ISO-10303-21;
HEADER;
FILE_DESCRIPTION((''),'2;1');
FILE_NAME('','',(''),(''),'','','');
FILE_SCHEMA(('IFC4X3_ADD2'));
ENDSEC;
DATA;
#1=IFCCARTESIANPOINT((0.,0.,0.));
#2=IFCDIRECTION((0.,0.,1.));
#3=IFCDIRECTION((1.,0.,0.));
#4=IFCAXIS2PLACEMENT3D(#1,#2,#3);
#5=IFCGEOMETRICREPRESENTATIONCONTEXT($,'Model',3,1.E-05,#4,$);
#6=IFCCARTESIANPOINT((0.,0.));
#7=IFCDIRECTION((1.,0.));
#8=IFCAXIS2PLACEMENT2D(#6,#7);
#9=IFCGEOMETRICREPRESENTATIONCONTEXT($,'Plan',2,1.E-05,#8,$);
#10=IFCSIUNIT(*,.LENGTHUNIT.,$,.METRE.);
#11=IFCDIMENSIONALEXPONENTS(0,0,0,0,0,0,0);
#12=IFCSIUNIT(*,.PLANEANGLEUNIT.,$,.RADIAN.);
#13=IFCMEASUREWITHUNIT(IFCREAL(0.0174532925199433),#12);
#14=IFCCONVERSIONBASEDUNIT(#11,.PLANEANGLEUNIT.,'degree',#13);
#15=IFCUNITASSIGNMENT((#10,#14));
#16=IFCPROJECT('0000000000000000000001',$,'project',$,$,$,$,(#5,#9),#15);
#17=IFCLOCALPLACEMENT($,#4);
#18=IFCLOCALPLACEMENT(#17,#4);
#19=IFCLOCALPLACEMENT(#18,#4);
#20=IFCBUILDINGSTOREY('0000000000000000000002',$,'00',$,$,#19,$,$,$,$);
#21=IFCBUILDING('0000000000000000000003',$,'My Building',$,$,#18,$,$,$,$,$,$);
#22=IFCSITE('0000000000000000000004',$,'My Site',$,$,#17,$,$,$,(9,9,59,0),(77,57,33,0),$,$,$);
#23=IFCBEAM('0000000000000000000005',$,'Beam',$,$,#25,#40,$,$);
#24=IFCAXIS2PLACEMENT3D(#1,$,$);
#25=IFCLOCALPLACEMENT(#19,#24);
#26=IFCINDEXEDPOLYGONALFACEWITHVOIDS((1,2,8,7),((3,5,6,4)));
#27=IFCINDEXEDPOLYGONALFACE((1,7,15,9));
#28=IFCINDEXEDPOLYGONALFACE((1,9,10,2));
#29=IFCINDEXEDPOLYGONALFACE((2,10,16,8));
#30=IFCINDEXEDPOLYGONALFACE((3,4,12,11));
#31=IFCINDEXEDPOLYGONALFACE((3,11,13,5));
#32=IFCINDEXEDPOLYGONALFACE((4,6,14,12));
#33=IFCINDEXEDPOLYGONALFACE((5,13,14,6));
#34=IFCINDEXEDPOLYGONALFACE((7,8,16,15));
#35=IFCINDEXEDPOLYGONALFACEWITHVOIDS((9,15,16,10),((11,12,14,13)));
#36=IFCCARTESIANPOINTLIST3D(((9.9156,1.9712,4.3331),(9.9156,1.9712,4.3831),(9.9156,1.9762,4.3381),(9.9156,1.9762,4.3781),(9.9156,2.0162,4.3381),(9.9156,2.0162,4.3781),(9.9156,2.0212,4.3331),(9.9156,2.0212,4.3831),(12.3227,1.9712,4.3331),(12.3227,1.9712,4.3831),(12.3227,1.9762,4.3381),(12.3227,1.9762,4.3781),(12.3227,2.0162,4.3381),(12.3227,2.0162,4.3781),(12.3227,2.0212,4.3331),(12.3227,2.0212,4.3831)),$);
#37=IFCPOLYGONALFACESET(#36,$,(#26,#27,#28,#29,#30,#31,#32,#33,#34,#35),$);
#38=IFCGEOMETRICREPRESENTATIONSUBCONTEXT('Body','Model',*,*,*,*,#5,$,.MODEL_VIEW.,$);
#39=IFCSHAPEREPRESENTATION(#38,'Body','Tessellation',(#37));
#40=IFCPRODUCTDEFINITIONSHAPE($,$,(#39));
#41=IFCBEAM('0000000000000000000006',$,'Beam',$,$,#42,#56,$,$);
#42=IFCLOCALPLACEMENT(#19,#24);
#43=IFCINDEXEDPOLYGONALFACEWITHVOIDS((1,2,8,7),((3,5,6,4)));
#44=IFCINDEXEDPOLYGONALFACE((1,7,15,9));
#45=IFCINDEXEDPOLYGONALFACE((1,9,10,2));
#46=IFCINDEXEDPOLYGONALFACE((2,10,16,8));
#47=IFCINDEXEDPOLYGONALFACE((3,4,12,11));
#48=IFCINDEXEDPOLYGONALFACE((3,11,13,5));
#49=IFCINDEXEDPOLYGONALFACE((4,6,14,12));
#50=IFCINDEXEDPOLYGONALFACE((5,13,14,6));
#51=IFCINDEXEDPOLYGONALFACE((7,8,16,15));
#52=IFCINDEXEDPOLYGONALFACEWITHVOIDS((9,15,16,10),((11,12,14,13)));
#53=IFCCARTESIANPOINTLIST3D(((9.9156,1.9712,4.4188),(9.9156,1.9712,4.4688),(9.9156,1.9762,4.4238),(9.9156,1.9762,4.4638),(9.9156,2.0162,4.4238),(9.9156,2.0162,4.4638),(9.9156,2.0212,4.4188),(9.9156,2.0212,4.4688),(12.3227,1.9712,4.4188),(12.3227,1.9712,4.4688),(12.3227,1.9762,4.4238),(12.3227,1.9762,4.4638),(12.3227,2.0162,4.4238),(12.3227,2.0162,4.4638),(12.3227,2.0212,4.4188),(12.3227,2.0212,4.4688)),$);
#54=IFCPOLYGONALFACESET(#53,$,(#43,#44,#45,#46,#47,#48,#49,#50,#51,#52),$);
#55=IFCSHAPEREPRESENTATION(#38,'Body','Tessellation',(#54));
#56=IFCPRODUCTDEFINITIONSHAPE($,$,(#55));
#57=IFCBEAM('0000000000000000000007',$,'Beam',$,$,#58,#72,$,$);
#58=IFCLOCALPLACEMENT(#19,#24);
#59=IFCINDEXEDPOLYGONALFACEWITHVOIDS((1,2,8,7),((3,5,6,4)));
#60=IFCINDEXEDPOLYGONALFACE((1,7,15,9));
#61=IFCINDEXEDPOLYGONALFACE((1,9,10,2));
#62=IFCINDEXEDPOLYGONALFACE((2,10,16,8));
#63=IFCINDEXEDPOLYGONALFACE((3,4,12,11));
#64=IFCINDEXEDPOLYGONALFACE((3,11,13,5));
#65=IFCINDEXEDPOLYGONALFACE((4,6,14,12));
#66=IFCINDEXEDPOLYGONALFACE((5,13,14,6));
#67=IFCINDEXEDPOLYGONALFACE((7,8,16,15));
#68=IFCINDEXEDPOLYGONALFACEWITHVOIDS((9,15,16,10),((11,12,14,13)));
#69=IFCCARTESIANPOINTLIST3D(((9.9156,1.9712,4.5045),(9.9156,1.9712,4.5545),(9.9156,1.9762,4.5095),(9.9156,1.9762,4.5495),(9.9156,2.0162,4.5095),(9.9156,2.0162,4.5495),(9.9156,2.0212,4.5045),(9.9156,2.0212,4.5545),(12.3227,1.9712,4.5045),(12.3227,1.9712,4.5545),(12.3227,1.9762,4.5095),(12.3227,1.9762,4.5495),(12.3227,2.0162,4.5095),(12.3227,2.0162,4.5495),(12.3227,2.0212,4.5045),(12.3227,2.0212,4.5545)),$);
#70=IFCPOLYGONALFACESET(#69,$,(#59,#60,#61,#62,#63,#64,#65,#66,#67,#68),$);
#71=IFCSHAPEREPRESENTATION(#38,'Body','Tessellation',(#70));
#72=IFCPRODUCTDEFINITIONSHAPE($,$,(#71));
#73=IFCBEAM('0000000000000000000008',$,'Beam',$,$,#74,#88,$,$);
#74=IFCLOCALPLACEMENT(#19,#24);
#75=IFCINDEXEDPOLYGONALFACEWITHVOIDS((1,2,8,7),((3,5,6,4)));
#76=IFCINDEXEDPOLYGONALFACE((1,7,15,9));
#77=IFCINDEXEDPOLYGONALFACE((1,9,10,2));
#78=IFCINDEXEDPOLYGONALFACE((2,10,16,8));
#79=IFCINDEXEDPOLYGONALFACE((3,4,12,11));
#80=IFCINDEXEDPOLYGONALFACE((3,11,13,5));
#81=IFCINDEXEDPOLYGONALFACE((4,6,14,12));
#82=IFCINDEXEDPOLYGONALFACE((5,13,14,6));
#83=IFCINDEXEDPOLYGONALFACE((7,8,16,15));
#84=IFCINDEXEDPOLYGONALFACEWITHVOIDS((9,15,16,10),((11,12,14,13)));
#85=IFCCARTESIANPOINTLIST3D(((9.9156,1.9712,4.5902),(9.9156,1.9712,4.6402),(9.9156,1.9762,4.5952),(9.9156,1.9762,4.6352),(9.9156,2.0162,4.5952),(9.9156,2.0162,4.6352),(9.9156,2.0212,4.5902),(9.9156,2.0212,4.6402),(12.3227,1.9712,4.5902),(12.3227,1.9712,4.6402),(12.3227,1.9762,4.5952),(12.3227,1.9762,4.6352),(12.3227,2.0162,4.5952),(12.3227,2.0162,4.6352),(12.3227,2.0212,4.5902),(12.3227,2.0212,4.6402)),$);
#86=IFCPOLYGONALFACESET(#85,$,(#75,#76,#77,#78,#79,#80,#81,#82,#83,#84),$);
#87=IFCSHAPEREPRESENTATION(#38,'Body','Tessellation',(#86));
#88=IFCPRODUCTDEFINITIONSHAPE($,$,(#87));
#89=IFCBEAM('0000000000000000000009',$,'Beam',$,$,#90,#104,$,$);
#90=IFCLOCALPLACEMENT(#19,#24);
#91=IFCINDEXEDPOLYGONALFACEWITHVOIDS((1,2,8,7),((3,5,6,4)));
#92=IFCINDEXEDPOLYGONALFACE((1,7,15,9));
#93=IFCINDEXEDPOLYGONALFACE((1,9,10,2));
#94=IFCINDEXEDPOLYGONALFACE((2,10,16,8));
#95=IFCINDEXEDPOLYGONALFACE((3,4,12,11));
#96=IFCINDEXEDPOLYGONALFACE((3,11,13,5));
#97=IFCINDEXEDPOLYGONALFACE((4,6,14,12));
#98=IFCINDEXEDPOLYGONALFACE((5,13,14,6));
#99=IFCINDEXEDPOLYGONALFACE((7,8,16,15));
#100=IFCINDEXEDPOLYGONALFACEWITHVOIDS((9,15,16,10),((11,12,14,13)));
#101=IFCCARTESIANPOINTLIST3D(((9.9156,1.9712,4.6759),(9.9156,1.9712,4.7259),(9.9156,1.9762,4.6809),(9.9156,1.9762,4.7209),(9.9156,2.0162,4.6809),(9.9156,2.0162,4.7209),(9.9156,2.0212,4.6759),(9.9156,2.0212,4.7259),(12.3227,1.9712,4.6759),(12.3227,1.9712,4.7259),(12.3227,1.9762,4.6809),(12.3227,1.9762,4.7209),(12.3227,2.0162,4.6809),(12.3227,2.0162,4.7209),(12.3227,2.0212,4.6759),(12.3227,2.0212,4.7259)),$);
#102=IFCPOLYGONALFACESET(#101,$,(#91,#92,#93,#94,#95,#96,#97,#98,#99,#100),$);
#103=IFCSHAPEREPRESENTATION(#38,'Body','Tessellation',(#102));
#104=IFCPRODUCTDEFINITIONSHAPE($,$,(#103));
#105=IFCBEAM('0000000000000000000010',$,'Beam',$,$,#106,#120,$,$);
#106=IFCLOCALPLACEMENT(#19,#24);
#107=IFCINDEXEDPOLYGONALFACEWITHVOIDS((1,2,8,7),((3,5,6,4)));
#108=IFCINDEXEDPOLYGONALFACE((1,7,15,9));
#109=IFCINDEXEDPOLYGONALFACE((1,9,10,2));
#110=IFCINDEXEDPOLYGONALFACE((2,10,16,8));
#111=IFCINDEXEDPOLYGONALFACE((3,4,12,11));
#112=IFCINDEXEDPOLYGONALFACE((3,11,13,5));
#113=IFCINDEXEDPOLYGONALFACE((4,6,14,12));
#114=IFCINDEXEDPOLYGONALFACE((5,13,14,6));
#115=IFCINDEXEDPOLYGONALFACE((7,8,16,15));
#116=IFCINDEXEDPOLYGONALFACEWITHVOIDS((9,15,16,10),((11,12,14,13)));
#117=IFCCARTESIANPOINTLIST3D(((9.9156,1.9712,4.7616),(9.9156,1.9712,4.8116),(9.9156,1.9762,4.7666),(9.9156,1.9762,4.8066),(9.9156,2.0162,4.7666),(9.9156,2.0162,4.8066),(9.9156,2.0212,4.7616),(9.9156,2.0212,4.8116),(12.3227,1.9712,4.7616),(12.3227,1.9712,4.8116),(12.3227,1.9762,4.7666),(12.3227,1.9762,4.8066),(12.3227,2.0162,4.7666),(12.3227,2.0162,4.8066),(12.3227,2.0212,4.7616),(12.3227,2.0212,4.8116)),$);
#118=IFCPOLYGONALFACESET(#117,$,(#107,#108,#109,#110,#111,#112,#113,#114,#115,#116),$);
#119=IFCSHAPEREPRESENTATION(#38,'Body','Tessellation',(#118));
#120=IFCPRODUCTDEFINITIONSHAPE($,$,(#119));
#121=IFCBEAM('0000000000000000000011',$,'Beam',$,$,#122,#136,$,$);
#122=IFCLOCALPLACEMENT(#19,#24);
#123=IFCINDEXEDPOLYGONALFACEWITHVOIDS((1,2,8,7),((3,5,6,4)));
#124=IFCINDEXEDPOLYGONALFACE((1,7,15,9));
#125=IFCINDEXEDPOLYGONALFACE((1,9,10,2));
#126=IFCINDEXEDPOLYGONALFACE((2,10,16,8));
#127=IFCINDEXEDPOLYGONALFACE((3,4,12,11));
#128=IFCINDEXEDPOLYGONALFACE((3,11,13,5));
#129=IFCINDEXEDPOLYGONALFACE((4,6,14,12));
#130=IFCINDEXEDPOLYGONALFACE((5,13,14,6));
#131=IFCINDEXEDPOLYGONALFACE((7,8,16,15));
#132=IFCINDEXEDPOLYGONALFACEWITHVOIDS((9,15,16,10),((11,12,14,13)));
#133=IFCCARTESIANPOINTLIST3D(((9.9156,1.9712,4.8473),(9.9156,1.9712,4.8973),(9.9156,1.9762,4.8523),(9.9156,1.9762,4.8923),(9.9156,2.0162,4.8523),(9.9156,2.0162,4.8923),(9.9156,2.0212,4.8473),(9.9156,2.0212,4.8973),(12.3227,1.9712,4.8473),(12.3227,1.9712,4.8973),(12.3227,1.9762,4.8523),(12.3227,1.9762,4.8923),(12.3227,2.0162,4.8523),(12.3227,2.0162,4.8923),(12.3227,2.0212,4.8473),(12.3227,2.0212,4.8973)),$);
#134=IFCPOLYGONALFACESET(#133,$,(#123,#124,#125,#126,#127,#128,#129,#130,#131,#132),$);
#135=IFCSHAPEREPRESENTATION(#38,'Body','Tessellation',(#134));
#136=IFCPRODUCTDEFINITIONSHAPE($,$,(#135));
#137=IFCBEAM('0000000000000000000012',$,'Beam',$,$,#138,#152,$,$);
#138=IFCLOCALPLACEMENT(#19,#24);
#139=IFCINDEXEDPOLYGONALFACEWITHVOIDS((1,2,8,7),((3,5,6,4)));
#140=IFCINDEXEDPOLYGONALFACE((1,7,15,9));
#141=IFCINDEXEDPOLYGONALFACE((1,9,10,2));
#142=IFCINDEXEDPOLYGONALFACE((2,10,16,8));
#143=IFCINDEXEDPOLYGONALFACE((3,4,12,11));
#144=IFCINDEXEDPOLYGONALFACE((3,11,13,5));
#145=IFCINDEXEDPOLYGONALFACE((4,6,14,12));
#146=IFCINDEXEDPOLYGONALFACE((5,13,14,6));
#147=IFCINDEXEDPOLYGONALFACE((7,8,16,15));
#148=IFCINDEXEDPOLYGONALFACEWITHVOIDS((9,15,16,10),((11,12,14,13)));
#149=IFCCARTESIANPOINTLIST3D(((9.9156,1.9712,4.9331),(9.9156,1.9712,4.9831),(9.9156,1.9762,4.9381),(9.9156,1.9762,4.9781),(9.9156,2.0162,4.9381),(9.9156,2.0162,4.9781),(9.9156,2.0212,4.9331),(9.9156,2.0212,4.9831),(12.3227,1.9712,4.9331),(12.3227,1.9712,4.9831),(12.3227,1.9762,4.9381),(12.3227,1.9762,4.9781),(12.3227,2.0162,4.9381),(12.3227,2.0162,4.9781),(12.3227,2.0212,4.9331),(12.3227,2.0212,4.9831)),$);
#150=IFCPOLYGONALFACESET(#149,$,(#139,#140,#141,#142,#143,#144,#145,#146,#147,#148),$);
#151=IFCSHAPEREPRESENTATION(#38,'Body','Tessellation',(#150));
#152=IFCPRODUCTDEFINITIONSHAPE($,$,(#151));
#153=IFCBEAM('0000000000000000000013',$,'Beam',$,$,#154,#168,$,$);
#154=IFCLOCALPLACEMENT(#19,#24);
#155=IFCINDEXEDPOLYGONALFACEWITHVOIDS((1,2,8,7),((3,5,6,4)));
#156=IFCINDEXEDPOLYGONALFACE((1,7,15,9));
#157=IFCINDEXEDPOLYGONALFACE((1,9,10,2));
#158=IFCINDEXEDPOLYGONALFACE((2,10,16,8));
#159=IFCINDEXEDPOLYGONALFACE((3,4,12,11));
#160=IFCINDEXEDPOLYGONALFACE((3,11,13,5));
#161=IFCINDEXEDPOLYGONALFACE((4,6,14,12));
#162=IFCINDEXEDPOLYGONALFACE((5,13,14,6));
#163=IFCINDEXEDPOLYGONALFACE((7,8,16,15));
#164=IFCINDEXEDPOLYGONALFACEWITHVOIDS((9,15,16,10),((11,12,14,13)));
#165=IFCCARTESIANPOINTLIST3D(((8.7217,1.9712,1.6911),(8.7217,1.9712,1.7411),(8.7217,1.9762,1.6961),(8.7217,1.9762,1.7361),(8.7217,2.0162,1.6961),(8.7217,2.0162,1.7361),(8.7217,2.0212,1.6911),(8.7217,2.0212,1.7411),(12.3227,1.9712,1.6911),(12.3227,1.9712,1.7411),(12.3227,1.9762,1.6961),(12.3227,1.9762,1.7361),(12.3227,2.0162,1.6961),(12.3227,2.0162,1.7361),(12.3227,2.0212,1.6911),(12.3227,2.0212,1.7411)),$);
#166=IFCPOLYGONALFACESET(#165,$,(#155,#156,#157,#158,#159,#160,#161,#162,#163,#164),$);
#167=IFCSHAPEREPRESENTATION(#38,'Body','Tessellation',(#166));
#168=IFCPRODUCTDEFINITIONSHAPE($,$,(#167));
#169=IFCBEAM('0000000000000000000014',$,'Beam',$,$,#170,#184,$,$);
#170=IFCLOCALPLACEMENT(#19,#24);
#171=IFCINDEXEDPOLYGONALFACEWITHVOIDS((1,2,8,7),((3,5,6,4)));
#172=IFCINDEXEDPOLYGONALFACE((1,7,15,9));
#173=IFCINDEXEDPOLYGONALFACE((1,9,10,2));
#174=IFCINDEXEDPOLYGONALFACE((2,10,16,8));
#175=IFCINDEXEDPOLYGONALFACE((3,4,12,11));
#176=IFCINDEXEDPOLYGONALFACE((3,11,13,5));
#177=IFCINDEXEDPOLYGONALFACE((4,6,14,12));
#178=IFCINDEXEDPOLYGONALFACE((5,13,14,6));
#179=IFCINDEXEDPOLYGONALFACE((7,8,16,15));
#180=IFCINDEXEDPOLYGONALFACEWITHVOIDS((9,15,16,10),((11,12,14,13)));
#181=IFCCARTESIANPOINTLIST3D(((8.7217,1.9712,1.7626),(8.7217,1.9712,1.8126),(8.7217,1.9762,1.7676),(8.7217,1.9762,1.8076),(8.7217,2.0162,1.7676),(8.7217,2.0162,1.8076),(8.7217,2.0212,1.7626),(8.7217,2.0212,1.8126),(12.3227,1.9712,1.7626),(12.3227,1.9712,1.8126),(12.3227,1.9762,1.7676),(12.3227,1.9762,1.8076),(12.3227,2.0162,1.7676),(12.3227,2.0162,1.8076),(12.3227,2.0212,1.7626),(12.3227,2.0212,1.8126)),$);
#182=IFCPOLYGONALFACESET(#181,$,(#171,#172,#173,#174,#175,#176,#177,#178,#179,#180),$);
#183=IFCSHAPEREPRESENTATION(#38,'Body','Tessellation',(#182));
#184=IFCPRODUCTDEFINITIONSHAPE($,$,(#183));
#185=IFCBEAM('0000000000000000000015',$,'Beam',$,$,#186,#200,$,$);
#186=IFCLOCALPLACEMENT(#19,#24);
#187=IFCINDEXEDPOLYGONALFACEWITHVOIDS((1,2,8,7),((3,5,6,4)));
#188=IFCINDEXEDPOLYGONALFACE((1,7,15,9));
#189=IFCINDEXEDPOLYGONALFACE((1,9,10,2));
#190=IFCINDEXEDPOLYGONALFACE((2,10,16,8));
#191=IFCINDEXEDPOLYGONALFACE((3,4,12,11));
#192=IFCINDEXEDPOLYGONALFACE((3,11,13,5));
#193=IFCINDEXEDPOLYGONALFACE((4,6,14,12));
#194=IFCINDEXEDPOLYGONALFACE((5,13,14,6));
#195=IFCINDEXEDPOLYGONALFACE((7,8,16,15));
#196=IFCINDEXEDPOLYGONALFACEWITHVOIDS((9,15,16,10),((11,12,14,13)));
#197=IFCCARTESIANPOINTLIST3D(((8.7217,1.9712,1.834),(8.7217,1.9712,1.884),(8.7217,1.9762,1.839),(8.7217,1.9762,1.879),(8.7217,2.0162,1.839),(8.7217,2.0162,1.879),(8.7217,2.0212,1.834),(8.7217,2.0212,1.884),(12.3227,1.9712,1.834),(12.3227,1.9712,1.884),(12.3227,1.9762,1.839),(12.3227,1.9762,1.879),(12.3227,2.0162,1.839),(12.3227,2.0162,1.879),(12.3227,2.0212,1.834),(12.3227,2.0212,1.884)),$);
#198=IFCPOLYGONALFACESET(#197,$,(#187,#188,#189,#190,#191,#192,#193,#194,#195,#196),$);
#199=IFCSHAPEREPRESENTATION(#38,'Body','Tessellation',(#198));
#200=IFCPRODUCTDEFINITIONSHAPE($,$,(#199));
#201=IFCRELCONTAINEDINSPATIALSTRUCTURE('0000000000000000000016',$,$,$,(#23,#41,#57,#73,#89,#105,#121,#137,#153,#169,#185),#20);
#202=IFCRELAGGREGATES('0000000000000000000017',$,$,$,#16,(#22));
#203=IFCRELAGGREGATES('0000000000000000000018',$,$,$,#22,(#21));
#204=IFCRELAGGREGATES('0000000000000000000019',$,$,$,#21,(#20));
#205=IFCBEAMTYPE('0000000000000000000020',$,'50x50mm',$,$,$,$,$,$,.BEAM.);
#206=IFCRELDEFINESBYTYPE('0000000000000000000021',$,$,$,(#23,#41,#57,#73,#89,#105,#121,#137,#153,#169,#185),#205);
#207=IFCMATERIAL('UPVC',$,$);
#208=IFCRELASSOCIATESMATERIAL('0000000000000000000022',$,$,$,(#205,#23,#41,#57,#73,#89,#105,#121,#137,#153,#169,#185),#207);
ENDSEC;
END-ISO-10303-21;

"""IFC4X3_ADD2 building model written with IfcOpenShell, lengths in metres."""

from ifc_helpers import new_model, entity, si_unit, converted_unit, frame, origin_with_axes, origin_2d_with_axis, place, context, subcontext, project, spatial, hollow_rectangle, extrude, material, material_profile, profile_set, profile_usage, type_object, element, save


model = new_model("IFC4X3_ADD2")

# Units and contexts
model_context = context("Model", 3, precision=1e-05, world=origin_with_axes())
plan_context = context("Plan", 2, precision=1e-05, world=origin_2d_with_axis())
body_context = subcontext(model_context, "Body", "Model", "MODEL_VIEW")
ifc_project = project(units=[si_unit("LENGTHUNIT", "METRE"), converted_unit("PLANEANGLEUNIT", "degree", entity("IfcReal", 0.0174532925199433), si_unit("PLANEANGLEUNIT", "RADIAN"), dimensions=[0, 0, 0, 0, 0, 0, 0])], contexts=[model_context, plan_context])

# Site, building, storey
site_placement = place(None, origin_with_axes())
site = spatial("IfcSite", under=ifc_project, at=site_placement, Name="My Site", RefLatitude=(9, 9, 59, 0), RefLongitude=(77, 57, 33, 0))
building_placement = place(site_placement, origin_with_axes())
building = spatial("IfcBuilding", under=site, at=building_placement, Name="My Building")
storey_placement = place(building_placement, origin_with_axes())
storey = spatial("IfcBuildingStorey", under=building, at=storey_placement, Name="00")

# Shared definitions
ifc_material_1 = material(Name="UPVC")

# Beams
ifc_material_profile_1 = material_profile(ifc_material_1, hollow_rectangle(XDim=0.05, YDim=0.05, WallThickness=0.005))
ifc_profile_set_1 = profile_set([ifc_material_profile_1])
beam_type = type_object("IfcBeamType", Name="50x50mm", PredefinedType="BEAM", material=ifc_profile_set_1)
ifc_profile_usage_1 = profile_usage(ifc_profile_set_1, cardinal=5)
beam_1_placement = place(storey_placement, frame((9.9156, 1.9962, 4.3581), z_axis=(1.0, 0.0, 0.000001), x_axis=(0.0, 1.0, 0.0)))
element("IfcBeam", 1, at=beam_1_placement, inside=storey, type_object=beam_type, material=ifc_profile_usage_1, Name="Beam", context=body_context, shape_type="SweptSolid", body=[
    extrude(hollow_rectangle(XDim=0.05, YDim=0.05, WallThickness=0.005), origin_with_axes(), (0.0, 0.0, 1.0), 2.4071),
])
ifc_profile_usage_2 = profile_usage(ifc_profile_set_1, cardinal=5)
beam_2_placement = place(storey_placement, frame((9.9156, 1.9962, 4.4438), z_axis=(1.0, 0.0, 0.000001), x_axis=(0.0, 1.0, 0.0)))
element("IfcBeam", 2, at=beam_2_placement, inside=storey, type_object=beam_type, material=ifc_profile_usage_2, Name="Beam", context=body_context, shape_type="SweptSolid", body=[
    extrude(hollow_rectangle(XDim=0.05, YDim=0.05, WallThickness=0.005), origin_with_axes(), (0.0, 0.0, 1.0), 2.4071),
])
ifc_profile_usage_3 = profile_usage(ifc_profile_set_1, cardinal=5)
beam_3_placement = place(storey_placement, frame((9.9156, 1.9962, 4.5295), z_axis=(1.0, 0.0, 0.000001), x_axis=(0.0, 1.0, 0.0)))
element("IfcBeam", 3, at=beam_3_placement, inside=storey, type_object=beam_type, material=ifc_profile_usage_3, Name="Beam", context=body_context, shape_type="SweptSolid", body=[
    extrude(hollow_rectangle(XDim=0.05, YDim=0.05, WallThickness=0.005), origin_with_axes(), (0.0, 0.0, 1.0), 2.4071),
])
ifc_profile_usage_4 = profile_usage(ifc_profile_set_1, cardinal=5)
beam_4_placement = place(storey_placement, frame((9.9156, 1.9962, 4.6152), z_axis=(1.0, 0.0, 0.000001), x_axis=(0.0, 1.0, 0.0)))
element("IfcBeam", 4, at=beam_4_placement, inside=storey, type_object=beam_type, material=ifc_profile_usage_4, Name="Beam", context=body_context, shape_type="SweptSolid", body=[
    extrude(hollow_rectangle(XDim=0.05, YDim=0.05, WallThickness=0.005), origin_with_axes(), (0.0, 0.0, 1.0), 2.4071),
])
ifc_profile_usage_5 = profile_usage(ifc_profile_set_1, cardinal=5)
beam_5_placement = place(storey_placement, frame((9.9156, 1.9962, 4.7009), z_axis=(1.0, 0.0, 0.000001), x_axis=(0.0, 1.0, 0.0)))
element("IfcBeam", 5, at=beam_5_placement, inside=storey, type_object=beam_type, material=ifc_profile_usage_5, Name="Beam", context=body_context, shape_type="SweptSolid", body=[
    extrude(hollow_rectangle(XDim=0.05, YDim=0.05, WallThickness=0.005), origin_with_axes(), (0.0, 0.0, 1.0), 2.4071),
])
ifc_profile_usage_6 = profile_usage(ifc_profile_set_1, cardinal=5)
beam_6_placement = place(storey_placement, frame((9.9156, 1.9962, 4.7866), z_axis=(1.0, 0.0, 0.000001), x_axis=(0.0, 1.0, 0.0)))
element("IfcBeam", 6, at=beam_6_placement, inside=storey, type_object=beam_type, material=ifc_profile_usage_6, Name="Beam", context=body_context, shape_type="SweptSolid", body=[
    extrude(hollow_rectangle(XDim=0.05, YDim=0.05, WallThickness=0.005), origin_with_axes(), (0.0, 0.0, 1.0), 2.4071),
])
ifc_profile_usage_7 = profile_usage(ifc_profile_set_1, cardinal=5)
beam_7_placement = place(storey_placement, frame((9.9156, 1.9962, 4.8723), z_axis=(1.0, 0.0, 0.000001), x_axis=(0.0, 1.0, 0.0)))
element("IfcBeam", 7, at=beam_7_placement, inside=storey, type_object=beam_type, material=ifc_profile_usage_7, Name="Beam", context=body_context, shape_type="SweptSolid", body=[
    extrude(hollow_rectangle(XDim=0.05, YDim=0.05, WallThickness=0.005), origin_with_axes(), (0.0, 0.0, 1.0), 2.4071),
])
ifc_profile_usage_8 = profile_usage(ifc_profile_set_1, cardinal=5)
beam_8_placement = place(storey_placement, frame((9.9156, 1.9962, 4.9581), z_axis=(1.0, 0.0, 0.000001), x_axis=(0.0, 1.0, 0.0)))
element("IfcBeam", 8, at=beam_8_placement, inside=storey, type_object=beam_type, material=ifc_profile_usage_8, Name="Beam", context=body_context, shape_type="SweptSolid", body=[
    extrude(hollow_rectangle(XDim=0.05, YDim=0.05, WallThickness=0.005), origin_with_axes(), (0.0, 0.0, 1.0), 2.4071),
])
ifc_profile_usage_9 = profile_usage(ifc_profile_set_1, cardinal=5)
beam_9_placement = place(storey_placement, frame((8.7217, 1.9962, 1.7161), z_axis=(1.0, 0.0, 0.000001), x_axis=(0.0, 1.0, 0.0)))
element("IfcBeam", 9, at=beam_9_placement, inside=storey, type_object=beam_type, material=ifc_profile_usage_9, Name="Beam", context=body_context, shape_type="SweptSolid", body=[
    extrude(hollow_rectangle(XDim=0.05, YDim=0.05, WallThickness=0.005), origin_with_axes(), (0.0, 0.0, 1.0), 3.601),
])
ifc_profile_usage_10 = profile_usage(ifc_profile_set_1, cardinal=5)
beam_10_placement = place(storey_placement, frame((8.7217, 1.9962, 1.7876), z_axis=(1.0, 0.0, 0.000001), x_axis=(0.0, 1.0, 0.0)))
element("IfcBeam", 10, at=beam_10_placement, inside=storey, type_object=beam_type, material=ifc_profile_usage_10, Name="Beam", context=body_context, shape_type="SweptSolid", body=[
    extrude(hollow_rectangle(XDim=0.05, YDim=0.05, WallThickness=0.005), origin_with_axes(), (0.0, 0.0, 1.0), 3.601),
])
ifc_profile_usage_11 = profile_usage(ifc_profile_set_1, cardinal=5)
beam_11_placement = place(storey_placement, frame((8.7217, 1.9962, 1.859), z_axis=(1.0, 0.0, 0.000001), x_axis=(0.0, 1.0, 0.0)))
element("IfcBeam", 11, at=beam_11_placement, inside=storey, type_object=beam_type, material=ifc_profile_usage_11, Name="Beam", context=body_context, shape_type="SweptSolid", body=[
    extrude(hollow_rectangle(XDim=0.05, YDim=0.05, WallThickness=0.005), origin_with_axes(), (0.0, 0.0, 1.0), 3.601),
])

save(model, "model.ifc")
